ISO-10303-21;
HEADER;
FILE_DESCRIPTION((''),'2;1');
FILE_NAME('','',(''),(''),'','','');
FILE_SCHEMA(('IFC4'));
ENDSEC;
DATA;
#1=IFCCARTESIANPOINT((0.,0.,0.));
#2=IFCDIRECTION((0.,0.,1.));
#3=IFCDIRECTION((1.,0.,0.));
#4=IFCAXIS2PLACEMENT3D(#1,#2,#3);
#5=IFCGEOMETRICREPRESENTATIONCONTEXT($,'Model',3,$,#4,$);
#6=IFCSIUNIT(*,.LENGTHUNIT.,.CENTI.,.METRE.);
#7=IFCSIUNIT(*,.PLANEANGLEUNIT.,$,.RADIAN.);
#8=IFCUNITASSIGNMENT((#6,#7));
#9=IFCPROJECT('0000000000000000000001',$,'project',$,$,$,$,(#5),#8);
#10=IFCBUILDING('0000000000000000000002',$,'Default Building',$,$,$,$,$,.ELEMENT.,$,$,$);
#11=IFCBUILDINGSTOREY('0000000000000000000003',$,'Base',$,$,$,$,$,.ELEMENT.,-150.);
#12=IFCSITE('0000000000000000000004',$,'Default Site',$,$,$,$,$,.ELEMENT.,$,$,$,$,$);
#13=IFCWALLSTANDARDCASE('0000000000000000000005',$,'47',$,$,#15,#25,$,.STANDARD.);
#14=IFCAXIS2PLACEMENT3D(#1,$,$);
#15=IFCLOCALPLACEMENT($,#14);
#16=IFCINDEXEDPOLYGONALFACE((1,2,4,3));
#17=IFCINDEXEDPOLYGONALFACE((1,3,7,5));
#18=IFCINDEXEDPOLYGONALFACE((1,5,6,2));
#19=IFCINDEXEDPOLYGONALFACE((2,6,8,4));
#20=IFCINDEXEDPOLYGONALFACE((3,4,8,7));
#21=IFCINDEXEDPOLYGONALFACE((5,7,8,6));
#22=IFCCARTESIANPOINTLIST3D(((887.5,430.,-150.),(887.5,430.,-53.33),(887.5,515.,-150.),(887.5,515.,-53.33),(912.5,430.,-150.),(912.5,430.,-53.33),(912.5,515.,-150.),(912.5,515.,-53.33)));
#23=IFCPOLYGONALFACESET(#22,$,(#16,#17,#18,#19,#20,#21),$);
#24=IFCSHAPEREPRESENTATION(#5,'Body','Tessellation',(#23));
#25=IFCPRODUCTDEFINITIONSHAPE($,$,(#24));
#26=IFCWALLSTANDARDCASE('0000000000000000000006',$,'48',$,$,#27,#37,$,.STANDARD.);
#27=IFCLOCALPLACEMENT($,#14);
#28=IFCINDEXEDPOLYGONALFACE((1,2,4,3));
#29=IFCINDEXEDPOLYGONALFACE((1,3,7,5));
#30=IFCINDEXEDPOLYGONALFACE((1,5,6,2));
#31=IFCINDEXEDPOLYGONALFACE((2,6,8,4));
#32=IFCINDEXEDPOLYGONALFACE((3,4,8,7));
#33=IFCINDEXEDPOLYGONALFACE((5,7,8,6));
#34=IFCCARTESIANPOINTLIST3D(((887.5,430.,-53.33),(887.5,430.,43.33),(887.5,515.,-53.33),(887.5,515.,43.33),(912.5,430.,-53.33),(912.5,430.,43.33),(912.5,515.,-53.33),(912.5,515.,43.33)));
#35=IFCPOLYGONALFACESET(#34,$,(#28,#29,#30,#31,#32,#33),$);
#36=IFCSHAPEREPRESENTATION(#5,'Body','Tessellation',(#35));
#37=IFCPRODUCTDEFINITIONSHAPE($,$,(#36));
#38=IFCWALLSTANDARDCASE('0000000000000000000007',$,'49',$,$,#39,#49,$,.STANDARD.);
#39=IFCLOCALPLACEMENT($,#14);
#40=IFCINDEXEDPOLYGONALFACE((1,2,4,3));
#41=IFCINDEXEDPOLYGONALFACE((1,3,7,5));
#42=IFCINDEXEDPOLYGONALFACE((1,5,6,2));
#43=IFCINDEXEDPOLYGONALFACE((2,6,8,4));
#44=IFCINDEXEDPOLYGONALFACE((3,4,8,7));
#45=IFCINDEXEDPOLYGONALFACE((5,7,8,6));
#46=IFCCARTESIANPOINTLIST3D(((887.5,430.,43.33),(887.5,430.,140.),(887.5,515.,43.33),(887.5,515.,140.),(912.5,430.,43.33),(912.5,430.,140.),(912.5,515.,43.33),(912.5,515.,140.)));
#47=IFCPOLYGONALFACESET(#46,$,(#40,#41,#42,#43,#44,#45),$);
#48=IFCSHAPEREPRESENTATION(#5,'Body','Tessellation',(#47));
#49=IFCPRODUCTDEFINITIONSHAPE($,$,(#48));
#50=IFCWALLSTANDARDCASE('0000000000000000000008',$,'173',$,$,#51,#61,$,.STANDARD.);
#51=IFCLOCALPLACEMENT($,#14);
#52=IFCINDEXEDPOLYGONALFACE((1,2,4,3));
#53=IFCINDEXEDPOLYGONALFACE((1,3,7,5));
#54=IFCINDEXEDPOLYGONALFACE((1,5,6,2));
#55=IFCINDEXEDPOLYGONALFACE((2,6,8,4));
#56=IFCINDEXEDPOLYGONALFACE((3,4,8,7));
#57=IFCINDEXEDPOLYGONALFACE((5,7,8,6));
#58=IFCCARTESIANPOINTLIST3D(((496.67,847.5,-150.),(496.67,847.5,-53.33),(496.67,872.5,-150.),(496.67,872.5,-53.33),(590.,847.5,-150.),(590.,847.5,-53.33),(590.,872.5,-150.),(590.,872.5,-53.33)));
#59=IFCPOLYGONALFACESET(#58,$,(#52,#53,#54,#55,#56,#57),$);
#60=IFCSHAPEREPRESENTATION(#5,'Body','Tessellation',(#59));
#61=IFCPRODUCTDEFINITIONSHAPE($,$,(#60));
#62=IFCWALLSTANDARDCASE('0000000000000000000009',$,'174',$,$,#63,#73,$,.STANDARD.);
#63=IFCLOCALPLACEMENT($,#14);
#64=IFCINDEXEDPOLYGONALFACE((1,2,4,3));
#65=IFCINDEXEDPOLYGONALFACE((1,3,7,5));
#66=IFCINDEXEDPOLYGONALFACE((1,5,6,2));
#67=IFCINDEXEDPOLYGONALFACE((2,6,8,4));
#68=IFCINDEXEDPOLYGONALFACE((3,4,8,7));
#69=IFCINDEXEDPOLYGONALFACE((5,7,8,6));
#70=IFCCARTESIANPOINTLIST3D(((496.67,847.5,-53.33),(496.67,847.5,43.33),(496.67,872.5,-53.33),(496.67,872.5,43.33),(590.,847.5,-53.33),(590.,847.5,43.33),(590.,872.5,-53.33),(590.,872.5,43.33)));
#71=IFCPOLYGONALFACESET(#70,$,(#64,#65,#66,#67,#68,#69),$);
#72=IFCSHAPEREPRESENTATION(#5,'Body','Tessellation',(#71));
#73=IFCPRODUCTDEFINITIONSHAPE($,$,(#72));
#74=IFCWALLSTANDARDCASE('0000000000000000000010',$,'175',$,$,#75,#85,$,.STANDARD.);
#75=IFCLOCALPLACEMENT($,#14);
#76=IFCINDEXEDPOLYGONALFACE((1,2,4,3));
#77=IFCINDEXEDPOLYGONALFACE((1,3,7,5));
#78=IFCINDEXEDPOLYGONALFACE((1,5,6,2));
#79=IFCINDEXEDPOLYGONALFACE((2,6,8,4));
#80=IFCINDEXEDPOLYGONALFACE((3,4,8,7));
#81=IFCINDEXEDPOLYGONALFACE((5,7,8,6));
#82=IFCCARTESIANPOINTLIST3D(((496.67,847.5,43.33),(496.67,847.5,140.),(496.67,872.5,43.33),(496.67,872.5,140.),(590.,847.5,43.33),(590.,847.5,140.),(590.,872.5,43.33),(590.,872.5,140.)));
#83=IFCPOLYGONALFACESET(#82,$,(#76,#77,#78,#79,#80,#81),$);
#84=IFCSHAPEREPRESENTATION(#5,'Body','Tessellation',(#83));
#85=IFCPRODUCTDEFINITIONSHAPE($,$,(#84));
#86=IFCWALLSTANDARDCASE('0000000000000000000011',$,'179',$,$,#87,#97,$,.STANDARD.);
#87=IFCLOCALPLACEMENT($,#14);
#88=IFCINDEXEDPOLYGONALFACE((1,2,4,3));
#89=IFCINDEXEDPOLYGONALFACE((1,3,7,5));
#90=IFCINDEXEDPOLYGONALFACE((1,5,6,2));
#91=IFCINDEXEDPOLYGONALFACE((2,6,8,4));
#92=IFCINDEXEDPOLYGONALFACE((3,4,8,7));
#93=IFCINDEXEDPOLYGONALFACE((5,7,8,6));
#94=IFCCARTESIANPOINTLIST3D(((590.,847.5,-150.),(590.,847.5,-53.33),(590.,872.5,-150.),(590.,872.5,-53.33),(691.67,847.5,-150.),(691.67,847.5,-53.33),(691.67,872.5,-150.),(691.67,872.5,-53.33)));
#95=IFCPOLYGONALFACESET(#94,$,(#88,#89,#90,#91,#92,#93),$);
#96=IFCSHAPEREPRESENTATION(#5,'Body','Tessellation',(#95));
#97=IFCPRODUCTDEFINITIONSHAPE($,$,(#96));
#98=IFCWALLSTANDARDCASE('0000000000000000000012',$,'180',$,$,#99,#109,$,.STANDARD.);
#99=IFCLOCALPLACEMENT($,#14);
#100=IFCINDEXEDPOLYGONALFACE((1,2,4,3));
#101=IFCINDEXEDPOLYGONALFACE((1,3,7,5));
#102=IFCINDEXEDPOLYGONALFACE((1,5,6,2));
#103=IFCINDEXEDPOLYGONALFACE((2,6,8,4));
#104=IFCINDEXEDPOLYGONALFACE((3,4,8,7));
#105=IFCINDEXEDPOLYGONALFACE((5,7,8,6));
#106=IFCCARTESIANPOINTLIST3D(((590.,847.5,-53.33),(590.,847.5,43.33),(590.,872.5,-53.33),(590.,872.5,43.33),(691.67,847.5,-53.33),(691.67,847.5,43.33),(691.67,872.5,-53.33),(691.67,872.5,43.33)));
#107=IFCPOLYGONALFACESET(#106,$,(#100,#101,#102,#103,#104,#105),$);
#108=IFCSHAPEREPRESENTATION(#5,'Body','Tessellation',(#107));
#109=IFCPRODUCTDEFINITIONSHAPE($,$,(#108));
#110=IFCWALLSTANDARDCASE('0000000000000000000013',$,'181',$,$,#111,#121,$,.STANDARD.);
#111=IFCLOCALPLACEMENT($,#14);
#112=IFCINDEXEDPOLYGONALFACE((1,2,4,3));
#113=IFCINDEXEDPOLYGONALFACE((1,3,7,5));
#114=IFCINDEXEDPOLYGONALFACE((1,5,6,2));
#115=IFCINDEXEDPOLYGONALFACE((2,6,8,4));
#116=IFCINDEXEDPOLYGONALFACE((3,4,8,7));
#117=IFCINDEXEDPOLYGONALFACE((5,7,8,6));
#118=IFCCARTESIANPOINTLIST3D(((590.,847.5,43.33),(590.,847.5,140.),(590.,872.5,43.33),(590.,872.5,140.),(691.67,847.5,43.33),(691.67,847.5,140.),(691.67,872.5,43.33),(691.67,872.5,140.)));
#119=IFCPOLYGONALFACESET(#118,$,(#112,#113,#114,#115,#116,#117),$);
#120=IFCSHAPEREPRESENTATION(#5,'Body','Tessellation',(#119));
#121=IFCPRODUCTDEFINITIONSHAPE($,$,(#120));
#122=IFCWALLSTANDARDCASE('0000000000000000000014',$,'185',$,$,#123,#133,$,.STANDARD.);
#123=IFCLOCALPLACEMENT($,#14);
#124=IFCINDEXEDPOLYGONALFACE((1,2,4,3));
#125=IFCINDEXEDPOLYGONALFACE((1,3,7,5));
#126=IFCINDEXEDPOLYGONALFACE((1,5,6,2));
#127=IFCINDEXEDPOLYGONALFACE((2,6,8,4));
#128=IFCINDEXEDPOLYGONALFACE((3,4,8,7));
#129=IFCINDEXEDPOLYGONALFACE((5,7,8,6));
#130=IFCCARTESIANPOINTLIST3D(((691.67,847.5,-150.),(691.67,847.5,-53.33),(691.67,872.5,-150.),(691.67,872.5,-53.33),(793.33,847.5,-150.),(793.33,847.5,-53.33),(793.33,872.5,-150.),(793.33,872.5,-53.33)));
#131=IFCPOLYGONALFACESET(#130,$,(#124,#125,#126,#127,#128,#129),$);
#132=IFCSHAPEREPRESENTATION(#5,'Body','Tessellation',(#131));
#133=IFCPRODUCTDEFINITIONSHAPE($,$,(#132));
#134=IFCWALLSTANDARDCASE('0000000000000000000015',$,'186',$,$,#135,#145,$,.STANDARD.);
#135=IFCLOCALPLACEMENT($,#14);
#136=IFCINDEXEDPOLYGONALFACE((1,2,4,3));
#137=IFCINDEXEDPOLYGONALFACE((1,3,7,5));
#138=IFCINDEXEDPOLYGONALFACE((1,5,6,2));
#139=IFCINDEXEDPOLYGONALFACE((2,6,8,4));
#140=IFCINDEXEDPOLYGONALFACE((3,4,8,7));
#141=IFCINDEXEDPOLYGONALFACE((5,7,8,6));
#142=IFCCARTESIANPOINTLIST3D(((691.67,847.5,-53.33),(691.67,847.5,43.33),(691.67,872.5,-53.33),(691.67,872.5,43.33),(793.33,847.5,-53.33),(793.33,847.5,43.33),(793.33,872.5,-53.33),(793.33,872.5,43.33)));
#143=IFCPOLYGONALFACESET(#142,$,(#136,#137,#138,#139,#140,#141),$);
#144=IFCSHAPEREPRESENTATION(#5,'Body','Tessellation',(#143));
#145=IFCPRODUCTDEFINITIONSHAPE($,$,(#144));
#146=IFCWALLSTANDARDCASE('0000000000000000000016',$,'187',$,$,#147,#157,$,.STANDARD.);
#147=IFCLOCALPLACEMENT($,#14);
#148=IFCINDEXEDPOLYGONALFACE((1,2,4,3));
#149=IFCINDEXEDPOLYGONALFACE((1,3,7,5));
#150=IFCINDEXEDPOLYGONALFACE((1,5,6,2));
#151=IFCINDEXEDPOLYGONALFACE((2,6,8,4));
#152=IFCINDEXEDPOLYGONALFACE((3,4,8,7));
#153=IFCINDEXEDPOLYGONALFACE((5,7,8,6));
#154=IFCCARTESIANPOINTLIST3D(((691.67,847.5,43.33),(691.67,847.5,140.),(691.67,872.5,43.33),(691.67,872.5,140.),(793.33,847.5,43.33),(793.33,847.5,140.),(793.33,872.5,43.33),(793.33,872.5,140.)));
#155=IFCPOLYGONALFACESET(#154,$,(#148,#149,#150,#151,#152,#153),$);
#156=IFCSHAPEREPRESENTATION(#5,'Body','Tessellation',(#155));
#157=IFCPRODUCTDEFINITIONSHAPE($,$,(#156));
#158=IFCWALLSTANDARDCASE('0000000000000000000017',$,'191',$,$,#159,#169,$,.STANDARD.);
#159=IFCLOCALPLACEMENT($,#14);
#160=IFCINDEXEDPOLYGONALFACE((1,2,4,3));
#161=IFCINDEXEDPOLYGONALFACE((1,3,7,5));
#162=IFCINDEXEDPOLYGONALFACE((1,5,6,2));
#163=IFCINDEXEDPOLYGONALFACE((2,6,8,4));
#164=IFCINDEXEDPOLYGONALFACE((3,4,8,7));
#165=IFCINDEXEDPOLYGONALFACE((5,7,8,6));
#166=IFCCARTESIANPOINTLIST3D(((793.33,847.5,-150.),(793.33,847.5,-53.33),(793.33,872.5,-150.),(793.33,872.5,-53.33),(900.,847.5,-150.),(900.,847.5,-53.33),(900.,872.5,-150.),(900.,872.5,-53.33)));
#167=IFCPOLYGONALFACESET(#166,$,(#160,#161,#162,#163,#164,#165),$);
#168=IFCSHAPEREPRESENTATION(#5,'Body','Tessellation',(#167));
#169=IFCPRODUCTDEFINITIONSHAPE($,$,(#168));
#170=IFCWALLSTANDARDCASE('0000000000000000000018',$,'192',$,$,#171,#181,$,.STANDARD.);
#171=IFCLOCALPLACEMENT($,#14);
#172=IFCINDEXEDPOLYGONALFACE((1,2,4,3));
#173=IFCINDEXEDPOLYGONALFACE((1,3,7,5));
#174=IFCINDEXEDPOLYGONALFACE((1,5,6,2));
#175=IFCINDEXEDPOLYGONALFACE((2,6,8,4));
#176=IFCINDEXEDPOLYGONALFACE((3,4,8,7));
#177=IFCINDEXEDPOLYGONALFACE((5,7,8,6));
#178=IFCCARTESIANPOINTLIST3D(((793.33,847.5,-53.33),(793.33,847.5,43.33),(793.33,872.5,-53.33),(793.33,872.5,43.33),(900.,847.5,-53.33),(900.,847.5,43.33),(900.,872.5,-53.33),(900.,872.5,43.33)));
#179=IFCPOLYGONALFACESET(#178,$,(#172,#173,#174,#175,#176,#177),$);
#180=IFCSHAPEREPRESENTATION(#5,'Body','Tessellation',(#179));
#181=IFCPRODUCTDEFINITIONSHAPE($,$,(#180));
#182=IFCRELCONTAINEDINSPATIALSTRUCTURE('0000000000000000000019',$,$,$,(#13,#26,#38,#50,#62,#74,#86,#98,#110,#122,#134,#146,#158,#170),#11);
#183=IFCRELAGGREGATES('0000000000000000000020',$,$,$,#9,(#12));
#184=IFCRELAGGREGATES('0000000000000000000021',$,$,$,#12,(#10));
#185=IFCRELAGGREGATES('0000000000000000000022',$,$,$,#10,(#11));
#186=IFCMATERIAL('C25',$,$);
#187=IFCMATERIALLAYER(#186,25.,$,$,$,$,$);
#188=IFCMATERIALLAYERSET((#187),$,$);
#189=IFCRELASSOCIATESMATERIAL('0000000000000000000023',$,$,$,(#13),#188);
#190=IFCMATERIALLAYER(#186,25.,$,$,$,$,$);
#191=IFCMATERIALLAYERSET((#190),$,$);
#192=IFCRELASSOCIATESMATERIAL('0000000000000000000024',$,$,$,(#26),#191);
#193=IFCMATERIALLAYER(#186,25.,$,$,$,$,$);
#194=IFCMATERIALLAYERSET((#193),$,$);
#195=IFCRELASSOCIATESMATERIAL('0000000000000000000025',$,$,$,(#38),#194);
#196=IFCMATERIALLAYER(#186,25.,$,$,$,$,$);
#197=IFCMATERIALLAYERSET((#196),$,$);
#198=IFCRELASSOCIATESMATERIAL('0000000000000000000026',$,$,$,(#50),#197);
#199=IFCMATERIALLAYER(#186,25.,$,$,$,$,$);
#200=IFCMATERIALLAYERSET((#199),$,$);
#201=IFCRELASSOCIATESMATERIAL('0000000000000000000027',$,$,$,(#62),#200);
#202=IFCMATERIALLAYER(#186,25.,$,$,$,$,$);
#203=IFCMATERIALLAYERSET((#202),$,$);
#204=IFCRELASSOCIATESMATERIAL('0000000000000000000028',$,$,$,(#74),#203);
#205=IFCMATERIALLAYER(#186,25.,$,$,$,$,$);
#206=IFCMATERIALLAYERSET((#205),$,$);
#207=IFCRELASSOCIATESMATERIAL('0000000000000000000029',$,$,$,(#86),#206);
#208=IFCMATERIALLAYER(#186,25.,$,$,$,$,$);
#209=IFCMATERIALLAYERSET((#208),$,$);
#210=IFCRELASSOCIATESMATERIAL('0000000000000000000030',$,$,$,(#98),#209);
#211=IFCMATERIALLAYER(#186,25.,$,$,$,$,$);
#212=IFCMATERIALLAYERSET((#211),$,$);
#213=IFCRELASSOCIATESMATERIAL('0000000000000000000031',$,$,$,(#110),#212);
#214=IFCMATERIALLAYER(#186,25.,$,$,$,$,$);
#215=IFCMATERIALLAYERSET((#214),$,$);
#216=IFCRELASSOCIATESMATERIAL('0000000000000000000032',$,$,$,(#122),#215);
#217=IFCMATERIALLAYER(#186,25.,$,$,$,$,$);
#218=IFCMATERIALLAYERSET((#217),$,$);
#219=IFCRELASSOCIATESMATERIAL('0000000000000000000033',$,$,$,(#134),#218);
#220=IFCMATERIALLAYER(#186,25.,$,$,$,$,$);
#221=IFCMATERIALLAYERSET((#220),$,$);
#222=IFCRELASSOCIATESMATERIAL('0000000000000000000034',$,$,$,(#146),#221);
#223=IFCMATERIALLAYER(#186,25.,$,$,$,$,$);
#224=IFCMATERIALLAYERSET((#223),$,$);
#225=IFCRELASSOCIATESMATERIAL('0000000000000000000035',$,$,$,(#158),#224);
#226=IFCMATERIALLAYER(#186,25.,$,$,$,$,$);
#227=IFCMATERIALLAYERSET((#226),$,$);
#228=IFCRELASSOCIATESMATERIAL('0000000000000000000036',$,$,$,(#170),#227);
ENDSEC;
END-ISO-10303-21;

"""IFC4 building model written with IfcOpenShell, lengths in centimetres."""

from ifc_helpers import new_model, si_unit, frame, origin_with_axes, origin_2d_with_axis, place, context, project, spatial, rectangle, extrude, material, layer, layer_set, layer_usage, element, save


model = new_model("IFC4")

# Units and contexts
model_context = context("Model", 3, world=origin_with_axes())
ifc_project = project(units=[si_unit("LENGTHUNIT", "METRE", prefix="CENTI"), si_unit("PLANEANGLEUNIT", "RADIAN")], contexts=[model_context])

# Site, building, storey
site = spatial("IfcSite", under=ifc_project, Name="Default Site", CompositionType="ELEMENT")
building = spatial("IfcBuilding", under=site, Name="Default Building", CompositionType="ELEMENT")
storey = spatial("IfcBuildingStorey", under=building, Name="Base", CompositionType="ELEMENT", Elevation=-150.0)

# Shared definitions
ifc_material = material(Name="C25")

# Walls
ifc_layer_1 = layer(ifc_material, 25.0)
ifc_layer_set_1 = layer_set([ifc_layer_1])
ifc_layer_usage_1 = layer_usage(ifc_layer_set_1, "AXIS2", "POSITIVE", -25.0)
wall_1_placement = place(None, frame((900.0, 472.5, -150.0), z_axis=(0.0, 0.0, 1.0), x_axis=(0.0, -1.0, 0.0)))
element("IfcWallStandardCase", 1, at=wall_1_placement, inside=storey, material=ifc_layer_usage_1, Name="47", PredefinedType="STANDARD", context=model_context, shape_type="SweptSolid", body=[
    extrude(rectangle(XDim=85.0, YDim=25.0, at=origin_2d_with_axis()), origin_with_axes(), (0.0, 0.0, 1.0), 96.67),
])
ifc_layer_2 = layer(ifc_material, 25.0)
ifc_layer_set_2 = layer_set([ifc_layer_2])
ifc_layer_usage_2 = layer_usage(ifc_layer_set_2, "AXIS2", "POSITIVE", -25.0)
wall_2_placement = place(None, frame((900.0, 472.5, -53.33), z_axis=(0.0, 0.0, 1.0), x_axis=(0.0, -1.0, 0.0)))
element("IfcWallStandardCase", 2, at=wall_2_placement, inside=storey, material=ifc_layer_usage_2, Name="48", PredefinedType="STANDARD", context=model_context, shape_type="SweptSolid", body=[
    extrude(rectangle(XDim=85.0, YDim=25.0, at=origin_2d_with_axis()), origin_with_axes(), (0.0, 0.0, 1.0), 96.67),
])
ifc_layer_3 = layer(ifc_material, 25.0)
ifc_layer_set_3 = layer_set([ifc_layer_3])
ifc_layer_usage_3 = layer_usage(ifc_layer_set_3, "AXIS2", "POSITIVE", -25.0)
wall_3_placement = place(None, frame((900.0, 472.5, 43.33), z_axis=(0.0, 0.0, 1.0), x_axis=(0.0, -1.0, 0.0)))
element("IfcWallStandardCase", 3, at=wall_3_placement, inside=storey, material=ifc_layer_usage_3, Name="49", PredefinedType="STANDARD", context=model_context, shape_type="SweptSolid", body=[
    extrude(rectangle(XDim=85.0, YDim=25.0, at=origin_2d_with_axis()), origin_with_axes(), (0.0, 0.0, 1.0), 96.67),
])
ifc_layer_4 = layer(ifc_material, 25.0)
ifc_layer_set_4 = layer_set([ifc_layer_4])
ifc_layer_usage_4 = layer_usage(ifc_layer_set_4, "AXIS2", "POSITIVE", -25.0)
wall_4_placement = place(None, frame((543.33, 860.0, -150.0), z_axis=(0.0, 0.0, 1.0), x_axis=(1.0, 0.0, 0.0)))
element("IfcWallStandardCase", 4, at=wall_4_placement, inside=storey, material=ifc_layer_usage_4, Name="173", PredefinedType="STANDARD", context=model_context, shape_type="SweptSolid", body=[
    extrude(rectangle(XDim=93.33, YDim=25.0, at=origin_2d_with_axis()), origin_with_axes(), (0.0, 0.0, 1.0), 96.67),
])
ifc_layer_5 = layer(ifc_material, 25.0)
ifc_layer_set_5 = layer_set([ifc_layer_5])
ifc_layer_usage_5 = layer_usage(ifc_layer_set_5, "AXIS2", "POSITIVE", -25.0)
wall_5_placement = place(None, frame((543.33, 860.0, -53.33), z_axis=(0.0, 0.0, 1.0), x_axis=(1.0, 0.0, 0.0)))
element("IfcWallStandardCase", 5, at=wall_5_placement, inside=storey, material=ifc_layer_usage_5, Name="174", PredefinedType="STANDARD", context=model_context, shape_type="SweptSolid", body=[
    extrude(rectangle(XDim=93.33, YDim=25.0, at=origin_2d_with_axis()), origin_with_axes(), (0.0, 0.0, 1.0), 96.67),
])
ifc_layer_6 = layer(ifc_material, 25.0)
ifc_layer_set_6 = layer_set([ifc_layer_6])
ifc_layer_usage_6 = layer_usage(ifc_layer_set_6, "AXIS2", "POSITIVE", -25.0)
wall_6_placement = place(None, frame((543.33, 860.0, 43.33), z_axis=(0.0, 0.0, 1.0), x_axis=(1.0, 0.0, 0.0)))
element("IfcWallStandardCase", 6, at=wall_6_placement, inside=storey, material=ifc_layer_usage_6, Name="175", PredefinedType="STANDARD", context=model_context, shape_type="SweptSolid", body=[
    extrude(rectangle(XDim=93.33, YDim=25.0, at=origin_2d_with_axis()), origin_with_axes(), (0.0, 0.0, 1.0), 96.67),
])
ifc_layer_7 = layer(ifc_material, 25.0)
ifc_layer_set_7 = layer_set([ifc_layer_7])
ifc_layer_usage_7 = layer_usage(ifc_layer_set_7, "AXIS2", "POSITIVE", -25.0)
wall_7_placement = place(None, frame((640.83, 860.0, -150.0), z_axis=(0.0, 0.0, 1.0), x_axis=(1.0, 0.0, 0.0)))
element("IfcWallStandardCase", 7, at=wall_7_placement, inside=storey, material=ifc_layer_usage_7, Name="179", PredefinedType="STANDARD", context=model_context, shape_type="SweptSolid", body=[
    extrude(rectangle(XDim=101.67, YDim=25.0, at=origin_2d_with_axis()), origin_with_axes(), (0.0, 0.0, 1.0), 96.67),
])
ifc_layer_8 = layer(ifc_material, 25.0)
ifc_layer_set_8 = layer_set([ifc_layer_8])
ifc_layer_usage_8 = layer_usage(ifc_layer_set_8, "AXIS2", "POSITIVE", -25.0)
wall_8_placement = place(None, frame((640.83, 860.0, -53.33), z_axis=(0.0, 0.0, 1.0), x_axis=(1.0, 0.0, 0.0)))
element("IfcWallStandardCase", 8, at=wall_8_placement, inside=storey, material=ifc_layer_usage_8, Name="180", PredefinedType="STANDARD", context=model_context, shape_type="SweptSolid", body=[
    extrude(rectangle(XDim=101.67, YDim=25.0, at=origin_2d_with_axis()), origin_with_axes(), (0.0, 0.0, 1.0), 96.67),
])
ifc_layer_9 = layer(ifc_material, 25.0)
ifc_layer_set_9 = layer_set([ifc_layer_9])
ifc_layer_usage_9 = layer_usage(ifc_layer_set_9, "AXIS2", "POSITIVE", -25.0)
wall_9_placement = place(None, frame((640.83, 860.0, 43.33), z_axis=(0.0, 0.0, 1.0), x_axis=(1.0, 0.0, 0.0)))
element("IfcWallStandardCase", 9, at=wall_9_placement, inside=storey, material=ifc_layer_usage_9, Name="181", PredefinedType="STANDARD", context=model_context, shape_type="SweptSolid", body=[
    extrude(rectangle(XDim=101.67, YDim=25.0, at=origin_2d_with_axis()), origin_with_axes(), (0.0, 0.0, 1.0), 96.67),
])
ifc_layer_10 = layer(ifc_material, 25.0)
ifc_layer_set_10 = layer_set([ifc_layer_10])
ifc_layer_usage_10 = layer_usage(ifc_layer_set_10, "AXIS2", "POSITIVE", -25.0)
wall_10_placement = place(None, frame((742.5, 860.0, -150.0), z_axis=(0.0, 0.0, 1.0), x_axis=(1.0, 0.0, 0.0)))
element("IfcWallStandardCase", 10, at=wall_10_placement, inside=storey, material=ifc_layer_usage_10, Name="185", PredefinedType="STANDARD", context=model_context, shape_type="SweptSolid", body=[
    extrude(rectangle(XDim=101.67, YDim=25.0, at=origin_2d_with_axis()), origin_with_axes(), (0.0, 0.0, 1.0), 96.67),
])
ifc_layer_11 = layer(ifc_material, 25.0)
ifc_layer_set_11 = layer_set([ifc_layer_11])
ifc_layer_usage_11 = layer_usage(ifc_layer_set_11, "AXIS2", "POSITIVE", -25.0)
wall_11_placement = place(None, frame((742.5, 860.0, -53.33), z_axis=(0.0, 0.0, 1.0), x_axis=(1.0, 0.0, 0.0)))
element("IfcWallStandardCase", 11, at=wall_11_placement, inside=storey, material=ifc_layer_usage_11, Name="186", PredefinedType="STANDARD", context=model_context, shape_type="SweptSolid", body=[
    extrude(rectangle(XDim=101.67, YDim=25.0, at=origin_2d_with_axis()), origin_with_axes(), (0.0, 0.0, 1.0), 96.67),
])
ifc_layer_12 = layer(ifc_material, 25.0)
ifc_layer_set_12 = layer_set([ifc_layer_12])
ifc_layer_usage_12 = layer_usage(ifc_layer_set_12, "AXIS2", "POSITIVE", -25.0)
wall_12_placement = place(None, frame((742.5, 860.0, 43.33), z_axis=(0.0, 0.0, 1.0), x_axis=(1.0, 0.0, 0.0)))
element("IfcWallStandardCase", 12, at=wall_12_placement, inside=storey, material=ifc_layer_usage_12, Name="187", PredefinedType="STANDARD", context=model_context, shape_type="SweptSolid", body=[
    extrude(rectangle(XDim=101.67, YDim=25.0, at=origin_2d_with_axis()), origin_with_axes(), (0.0, 0.0, 1.0), 96.67),
])
ifc_layer_13 = layer(ifc_material, 25.0)
ifc_layer_set_13 = layer_set([ifc_layer_13])
ifc_layer_usage_13 = layer_usage(ifc_layer_set_13, "AXIS2", "POSITIVE", -25.0)
wall_13_placement = place(None, frame((846.67, 860.0, -150.0), z_axis=(0.0, 0.0, 1.0), x_axis=(1.0, 0.0, 0.0)))
element("IfcWallStandardCase", 13, at=wall_13_placement, inside=storey, material=ifc_layer_usage_13, Name="191", PredefinedType="STANDARD", context=model_context, shape_type="SweptSolid", body=[
    extrude(rectangle(XDim=106.67, YDim=25.0, at=origin_2d_with_axis()), origin_with_axes(), (0.0, 0.0, 1.0), 96.67),
])
ifc_layer_14 = layer(ifc_material, 25.0)
ifc_layer_set_14 = layer_set([ifc_layer_14])
ifc_layer_usage_14 = layer_usage(ifc_layer_set_14, "AXIS2", "POSITIVE", -25.0)
wall_14_placement = place(None, frame((846.67, 860.0, -53.33), z_axis=(0.0, 0.0, 1.0), x_axis=(1.0, 0.0, 0.0)))
element("IfcWallStandardCase", 14, at=wall_14_placement, inside=storey, material=ifc_layer_usage_14, Name="192", PredefinedType="STANDARD", context=model_context, shape_type="SweptSolid", body=[
    extrude(rectangle(XDim=106.67, YDim=25.0, at=origin_2d_with_axis()), origin_with_axes(), (0.0, 0.0, 1.0), 96.67),
])

save(model, "model.ifc")
